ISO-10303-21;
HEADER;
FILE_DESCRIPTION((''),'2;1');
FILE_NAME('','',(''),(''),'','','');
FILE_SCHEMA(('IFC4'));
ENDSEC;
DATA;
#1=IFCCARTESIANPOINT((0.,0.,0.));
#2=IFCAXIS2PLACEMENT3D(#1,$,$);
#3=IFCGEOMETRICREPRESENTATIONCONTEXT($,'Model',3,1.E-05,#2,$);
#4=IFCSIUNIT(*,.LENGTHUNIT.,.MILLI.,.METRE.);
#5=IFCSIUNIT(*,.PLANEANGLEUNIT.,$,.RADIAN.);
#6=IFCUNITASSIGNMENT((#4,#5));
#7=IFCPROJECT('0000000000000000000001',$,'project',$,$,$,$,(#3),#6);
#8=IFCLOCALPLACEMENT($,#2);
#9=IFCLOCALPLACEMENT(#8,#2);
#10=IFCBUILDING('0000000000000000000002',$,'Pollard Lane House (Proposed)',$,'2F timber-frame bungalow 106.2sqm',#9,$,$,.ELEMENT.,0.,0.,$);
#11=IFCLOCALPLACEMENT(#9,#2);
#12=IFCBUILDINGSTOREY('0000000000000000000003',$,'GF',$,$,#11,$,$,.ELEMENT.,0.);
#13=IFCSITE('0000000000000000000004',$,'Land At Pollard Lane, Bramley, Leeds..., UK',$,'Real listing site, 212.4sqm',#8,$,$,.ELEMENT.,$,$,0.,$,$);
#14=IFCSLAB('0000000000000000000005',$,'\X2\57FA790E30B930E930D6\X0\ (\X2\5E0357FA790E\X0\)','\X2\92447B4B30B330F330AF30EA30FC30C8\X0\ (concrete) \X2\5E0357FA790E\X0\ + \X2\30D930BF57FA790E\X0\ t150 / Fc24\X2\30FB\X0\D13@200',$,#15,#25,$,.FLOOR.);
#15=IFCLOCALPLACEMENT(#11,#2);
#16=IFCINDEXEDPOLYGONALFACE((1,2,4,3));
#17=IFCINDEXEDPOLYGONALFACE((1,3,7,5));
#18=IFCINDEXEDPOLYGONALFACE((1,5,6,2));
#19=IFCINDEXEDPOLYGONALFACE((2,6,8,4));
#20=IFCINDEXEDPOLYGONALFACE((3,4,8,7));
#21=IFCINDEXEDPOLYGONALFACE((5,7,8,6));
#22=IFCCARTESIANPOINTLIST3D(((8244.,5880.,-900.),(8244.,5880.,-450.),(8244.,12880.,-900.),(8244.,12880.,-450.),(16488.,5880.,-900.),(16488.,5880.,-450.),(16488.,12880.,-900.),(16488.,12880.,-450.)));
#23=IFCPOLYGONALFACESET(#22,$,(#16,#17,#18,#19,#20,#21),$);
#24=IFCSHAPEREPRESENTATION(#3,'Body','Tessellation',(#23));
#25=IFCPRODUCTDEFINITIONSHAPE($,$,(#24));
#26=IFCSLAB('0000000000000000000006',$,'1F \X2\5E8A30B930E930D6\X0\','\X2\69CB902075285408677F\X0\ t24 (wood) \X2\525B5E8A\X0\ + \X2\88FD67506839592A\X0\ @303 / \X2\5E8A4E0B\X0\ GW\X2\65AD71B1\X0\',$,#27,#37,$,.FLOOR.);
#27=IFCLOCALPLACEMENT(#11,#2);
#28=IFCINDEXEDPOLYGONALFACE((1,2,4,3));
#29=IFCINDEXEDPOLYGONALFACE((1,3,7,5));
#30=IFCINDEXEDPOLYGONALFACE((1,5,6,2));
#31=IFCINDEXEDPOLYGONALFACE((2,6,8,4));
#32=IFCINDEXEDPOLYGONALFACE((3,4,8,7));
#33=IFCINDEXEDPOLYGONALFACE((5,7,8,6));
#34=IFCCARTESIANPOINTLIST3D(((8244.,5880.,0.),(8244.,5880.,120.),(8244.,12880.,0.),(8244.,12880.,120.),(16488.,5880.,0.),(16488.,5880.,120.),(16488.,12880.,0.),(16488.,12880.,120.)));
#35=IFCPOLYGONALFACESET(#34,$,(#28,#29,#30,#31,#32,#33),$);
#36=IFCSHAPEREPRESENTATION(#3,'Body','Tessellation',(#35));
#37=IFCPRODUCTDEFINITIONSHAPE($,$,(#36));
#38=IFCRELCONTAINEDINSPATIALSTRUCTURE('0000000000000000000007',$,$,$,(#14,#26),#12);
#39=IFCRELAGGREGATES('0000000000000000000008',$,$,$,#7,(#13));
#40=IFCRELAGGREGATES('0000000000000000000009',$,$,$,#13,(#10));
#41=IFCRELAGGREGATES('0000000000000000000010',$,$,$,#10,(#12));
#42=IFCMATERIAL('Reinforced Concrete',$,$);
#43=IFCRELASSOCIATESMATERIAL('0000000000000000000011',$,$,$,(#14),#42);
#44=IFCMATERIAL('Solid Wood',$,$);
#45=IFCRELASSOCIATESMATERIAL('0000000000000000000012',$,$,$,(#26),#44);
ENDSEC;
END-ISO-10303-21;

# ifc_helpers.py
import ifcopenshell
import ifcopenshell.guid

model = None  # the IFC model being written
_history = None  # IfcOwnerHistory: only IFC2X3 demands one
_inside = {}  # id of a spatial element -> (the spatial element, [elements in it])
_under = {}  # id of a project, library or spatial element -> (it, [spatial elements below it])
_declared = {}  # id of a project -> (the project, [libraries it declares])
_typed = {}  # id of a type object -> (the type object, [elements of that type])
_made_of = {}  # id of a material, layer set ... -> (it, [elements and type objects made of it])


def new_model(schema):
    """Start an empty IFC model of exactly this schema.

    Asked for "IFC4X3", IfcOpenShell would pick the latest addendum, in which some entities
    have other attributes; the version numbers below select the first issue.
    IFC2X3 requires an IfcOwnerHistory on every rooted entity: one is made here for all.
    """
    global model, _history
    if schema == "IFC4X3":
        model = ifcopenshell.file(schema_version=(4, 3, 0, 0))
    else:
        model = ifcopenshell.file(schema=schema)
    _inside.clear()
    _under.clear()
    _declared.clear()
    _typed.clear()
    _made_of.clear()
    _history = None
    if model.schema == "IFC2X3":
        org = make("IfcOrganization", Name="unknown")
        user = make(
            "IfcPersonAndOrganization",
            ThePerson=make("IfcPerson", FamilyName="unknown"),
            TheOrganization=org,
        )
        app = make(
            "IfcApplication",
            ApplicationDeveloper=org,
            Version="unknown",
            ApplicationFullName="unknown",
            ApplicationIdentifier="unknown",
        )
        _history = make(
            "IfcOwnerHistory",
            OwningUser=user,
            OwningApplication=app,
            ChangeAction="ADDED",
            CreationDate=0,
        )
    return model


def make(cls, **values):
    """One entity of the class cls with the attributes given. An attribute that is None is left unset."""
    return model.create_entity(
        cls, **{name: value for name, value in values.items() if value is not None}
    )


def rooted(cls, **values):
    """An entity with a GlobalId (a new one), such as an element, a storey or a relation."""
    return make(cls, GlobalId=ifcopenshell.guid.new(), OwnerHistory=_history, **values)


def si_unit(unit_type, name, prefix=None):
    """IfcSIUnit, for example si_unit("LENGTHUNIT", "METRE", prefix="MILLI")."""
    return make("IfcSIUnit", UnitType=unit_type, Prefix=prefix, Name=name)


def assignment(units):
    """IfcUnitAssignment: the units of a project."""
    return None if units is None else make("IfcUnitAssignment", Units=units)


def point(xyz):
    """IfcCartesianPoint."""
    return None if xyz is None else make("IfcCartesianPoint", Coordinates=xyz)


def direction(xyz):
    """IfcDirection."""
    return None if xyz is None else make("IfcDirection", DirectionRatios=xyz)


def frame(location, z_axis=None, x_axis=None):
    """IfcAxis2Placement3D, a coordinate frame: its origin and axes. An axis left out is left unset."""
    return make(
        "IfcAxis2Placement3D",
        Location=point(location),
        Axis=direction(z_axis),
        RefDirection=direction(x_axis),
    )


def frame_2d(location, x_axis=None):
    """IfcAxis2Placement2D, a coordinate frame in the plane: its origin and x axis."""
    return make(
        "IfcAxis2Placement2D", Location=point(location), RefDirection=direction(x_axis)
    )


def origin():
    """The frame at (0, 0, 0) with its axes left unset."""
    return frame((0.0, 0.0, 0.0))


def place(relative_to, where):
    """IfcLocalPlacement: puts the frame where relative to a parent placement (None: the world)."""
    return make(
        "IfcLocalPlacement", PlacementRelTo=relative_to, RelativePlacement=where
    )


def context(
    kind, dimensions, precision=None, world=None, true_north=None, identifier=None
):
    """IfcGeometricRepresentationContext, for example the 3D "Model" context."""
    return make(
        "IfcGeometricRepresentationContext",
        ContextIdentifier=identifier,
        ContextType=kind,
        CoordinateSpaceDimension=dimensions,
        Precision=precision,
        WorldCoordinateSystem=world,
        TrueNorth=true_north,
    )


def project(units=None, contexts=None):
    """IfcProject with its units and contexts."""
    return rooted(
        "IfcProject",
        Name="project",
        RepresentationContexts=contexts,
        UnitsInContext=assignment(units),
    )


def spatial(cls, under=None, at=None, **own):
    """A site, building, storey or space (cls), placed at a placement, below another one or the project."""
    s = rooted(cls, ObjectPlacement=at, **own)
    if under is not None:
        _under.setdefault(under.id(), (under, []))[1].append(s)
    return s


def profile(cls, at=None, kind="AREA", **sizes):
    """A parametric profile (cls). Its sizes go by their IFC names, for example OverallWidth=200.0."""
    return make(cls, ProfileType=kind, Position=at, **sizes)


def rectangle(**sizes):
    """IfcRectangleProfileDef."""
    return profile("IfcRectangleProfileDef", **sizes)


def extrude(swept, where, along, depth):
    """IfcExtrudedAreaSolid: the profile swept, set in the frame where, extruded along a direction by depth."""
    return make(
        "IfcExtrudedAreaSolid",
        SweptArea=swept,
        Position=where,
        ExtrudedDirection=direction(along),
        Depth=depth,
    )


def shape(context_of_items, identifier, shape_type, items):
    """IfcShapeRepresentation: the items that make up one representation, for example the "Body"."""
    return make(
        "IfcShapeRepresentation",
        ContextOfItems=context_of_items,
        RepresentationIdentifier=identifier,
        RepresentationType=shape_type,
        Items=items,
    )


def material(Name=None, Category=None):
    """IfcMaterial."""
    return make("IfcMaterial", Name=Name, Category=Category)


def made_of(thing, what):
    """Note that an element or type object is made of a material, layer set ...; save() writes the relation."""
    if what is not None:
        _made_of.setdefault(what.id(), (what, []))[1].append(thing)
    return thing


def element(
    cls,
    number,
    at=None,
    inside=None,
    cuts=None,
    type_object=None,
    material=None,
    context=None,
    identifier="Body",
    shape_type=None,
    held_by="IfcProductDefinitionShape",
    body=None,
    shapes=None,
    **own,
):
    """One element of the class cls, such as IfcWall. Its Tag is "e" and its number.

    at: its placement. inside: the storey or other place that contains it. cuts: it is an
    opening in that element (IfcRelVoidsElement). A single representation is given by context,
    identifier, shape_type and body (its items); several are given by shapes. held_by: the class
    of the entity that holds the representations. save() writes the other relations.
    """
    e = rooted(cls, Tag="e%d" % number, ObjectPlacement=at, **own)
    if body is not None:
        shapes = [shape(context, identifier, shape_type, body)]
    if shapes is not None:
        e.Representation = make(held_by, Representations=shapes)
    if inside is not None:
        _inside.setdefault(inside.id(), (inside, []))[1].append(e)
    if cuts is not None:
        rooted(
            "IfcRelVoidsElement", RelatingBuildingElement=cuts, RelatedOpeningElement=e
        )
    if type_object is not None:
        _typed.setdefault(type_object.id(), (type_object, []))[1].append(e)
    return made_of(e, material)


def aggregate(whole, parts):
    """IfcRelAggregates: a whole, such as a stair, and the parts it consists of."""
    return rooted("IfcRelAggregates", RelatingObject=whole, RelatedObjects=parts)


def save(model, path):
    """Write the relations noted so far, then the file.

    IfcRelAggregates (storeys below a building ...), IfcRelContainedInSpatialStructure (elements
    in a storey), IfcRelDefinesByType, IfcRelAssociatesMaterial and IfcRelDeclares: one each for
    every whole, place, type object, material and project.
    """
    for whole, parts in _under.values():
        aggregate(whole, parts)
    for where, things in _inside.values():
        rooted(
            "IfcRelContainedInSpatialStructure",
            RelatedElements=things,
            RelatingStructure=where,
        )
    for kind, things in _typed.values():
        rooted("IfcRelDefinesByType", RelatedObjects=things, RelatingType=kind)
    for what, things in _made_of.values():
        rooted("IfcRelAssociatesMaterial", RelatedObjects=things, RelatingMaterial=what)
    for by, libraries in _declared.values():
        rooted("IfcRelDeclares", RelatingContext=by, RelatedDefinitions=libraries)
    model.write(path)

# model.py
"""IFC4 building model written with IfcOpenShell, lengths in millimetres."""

from ifc_helpers import new_model, si_unit, frame, frame_2d, origin, place, context, project, spatial, rectangle, extrude, material, element, save


model = new_model("IFC4")

# Units and contexts
model_context = context("Model", 3, precision=1e-05, world=origin())
ifc_project = project(units=[si_unit("LENGTHUNIT", "METRE", prefix="MILLI"), si_unit("PLANEANGLEUNIT", "RADIAN")], contexts=[model_context])

# Site, building, storey
site_placement = place(None, origin())
site = spatial("IfcSite", under=ifc_project, at=site_placement, Name="Land At Pollard Lane, Bramley, Leeds..., UK", ObjectType="Real listing site, 212.4sqm", CompositionType="ELEMENT", RefElevation=0.0)
building_placement = place(site_placement, origin())
building = spatial("IfcBuilding", under=site, at=building_placement, Name="Pollard Lane House (Proposed)", ObjectType="2F timber-frame bungalow 106.2sqm", CompositionType="ELEMENT", ElevationOfRefHeight=0.0, ElevationOfTerrain=0.0)
storey_placement = place(building_placement, origin())
storey = spatial("IfcBuildingStorey", under=building, at=storey_placement, Name="GF", CompositionType="ELEMENT", Elevation=0.0)

# Slabs
ifc_material_1 = material(Name="Reinforced Concrete")
slab_1_placement = place(storey_placement, frame((4122.0, 2940.0, -450.0)))
element("IfcSlab", 1, at=slab_1_placement, inside=storey, material=ifc_material_1, Name="基礎スラブ (布基礎)", Description="鉄筋コンクリート (concrete) 布基礎 + ベタ基礎 t150 / Fc24・D13@200", PredefinedType="FLOOR", context=model_context, shape_type="SweptSolid", body=[
    extrude(rectangle(XDim=8244.0, YDim=7000.0, at=frame_2d((4122.0, 3500.0))), frame((4122.0, 2940.0, -450.0)), (0.0, 0.0, 1.0), 450.0),
])
ifc_material_2 = material(Name="Solid Wood")
slab_2_placement = place(storey_placement, frame((4122.0, 2940.0, 0.0)))
element("IfcSlab", 2, at=slab_2_placement, inside=storey, material=ifc_material_2, Name="1F 床スラブ", Description="構造用合板 t24 (wood) 剛床 + 製材根太 @303 / 床下 GW断熱", PredefinedType="FLOOR", context=model_context, shape_type="SweptSolid", body=[
    extrude(rectangle(XDim=8244.0, YDim=7000.0, at=frame_2d((4122.0, 3500.0))), frame((4122.0, 2940.0, 0.0)), (0.0, 0.0, 1.0), 120.0),
])

save(model, "model.ifc")
